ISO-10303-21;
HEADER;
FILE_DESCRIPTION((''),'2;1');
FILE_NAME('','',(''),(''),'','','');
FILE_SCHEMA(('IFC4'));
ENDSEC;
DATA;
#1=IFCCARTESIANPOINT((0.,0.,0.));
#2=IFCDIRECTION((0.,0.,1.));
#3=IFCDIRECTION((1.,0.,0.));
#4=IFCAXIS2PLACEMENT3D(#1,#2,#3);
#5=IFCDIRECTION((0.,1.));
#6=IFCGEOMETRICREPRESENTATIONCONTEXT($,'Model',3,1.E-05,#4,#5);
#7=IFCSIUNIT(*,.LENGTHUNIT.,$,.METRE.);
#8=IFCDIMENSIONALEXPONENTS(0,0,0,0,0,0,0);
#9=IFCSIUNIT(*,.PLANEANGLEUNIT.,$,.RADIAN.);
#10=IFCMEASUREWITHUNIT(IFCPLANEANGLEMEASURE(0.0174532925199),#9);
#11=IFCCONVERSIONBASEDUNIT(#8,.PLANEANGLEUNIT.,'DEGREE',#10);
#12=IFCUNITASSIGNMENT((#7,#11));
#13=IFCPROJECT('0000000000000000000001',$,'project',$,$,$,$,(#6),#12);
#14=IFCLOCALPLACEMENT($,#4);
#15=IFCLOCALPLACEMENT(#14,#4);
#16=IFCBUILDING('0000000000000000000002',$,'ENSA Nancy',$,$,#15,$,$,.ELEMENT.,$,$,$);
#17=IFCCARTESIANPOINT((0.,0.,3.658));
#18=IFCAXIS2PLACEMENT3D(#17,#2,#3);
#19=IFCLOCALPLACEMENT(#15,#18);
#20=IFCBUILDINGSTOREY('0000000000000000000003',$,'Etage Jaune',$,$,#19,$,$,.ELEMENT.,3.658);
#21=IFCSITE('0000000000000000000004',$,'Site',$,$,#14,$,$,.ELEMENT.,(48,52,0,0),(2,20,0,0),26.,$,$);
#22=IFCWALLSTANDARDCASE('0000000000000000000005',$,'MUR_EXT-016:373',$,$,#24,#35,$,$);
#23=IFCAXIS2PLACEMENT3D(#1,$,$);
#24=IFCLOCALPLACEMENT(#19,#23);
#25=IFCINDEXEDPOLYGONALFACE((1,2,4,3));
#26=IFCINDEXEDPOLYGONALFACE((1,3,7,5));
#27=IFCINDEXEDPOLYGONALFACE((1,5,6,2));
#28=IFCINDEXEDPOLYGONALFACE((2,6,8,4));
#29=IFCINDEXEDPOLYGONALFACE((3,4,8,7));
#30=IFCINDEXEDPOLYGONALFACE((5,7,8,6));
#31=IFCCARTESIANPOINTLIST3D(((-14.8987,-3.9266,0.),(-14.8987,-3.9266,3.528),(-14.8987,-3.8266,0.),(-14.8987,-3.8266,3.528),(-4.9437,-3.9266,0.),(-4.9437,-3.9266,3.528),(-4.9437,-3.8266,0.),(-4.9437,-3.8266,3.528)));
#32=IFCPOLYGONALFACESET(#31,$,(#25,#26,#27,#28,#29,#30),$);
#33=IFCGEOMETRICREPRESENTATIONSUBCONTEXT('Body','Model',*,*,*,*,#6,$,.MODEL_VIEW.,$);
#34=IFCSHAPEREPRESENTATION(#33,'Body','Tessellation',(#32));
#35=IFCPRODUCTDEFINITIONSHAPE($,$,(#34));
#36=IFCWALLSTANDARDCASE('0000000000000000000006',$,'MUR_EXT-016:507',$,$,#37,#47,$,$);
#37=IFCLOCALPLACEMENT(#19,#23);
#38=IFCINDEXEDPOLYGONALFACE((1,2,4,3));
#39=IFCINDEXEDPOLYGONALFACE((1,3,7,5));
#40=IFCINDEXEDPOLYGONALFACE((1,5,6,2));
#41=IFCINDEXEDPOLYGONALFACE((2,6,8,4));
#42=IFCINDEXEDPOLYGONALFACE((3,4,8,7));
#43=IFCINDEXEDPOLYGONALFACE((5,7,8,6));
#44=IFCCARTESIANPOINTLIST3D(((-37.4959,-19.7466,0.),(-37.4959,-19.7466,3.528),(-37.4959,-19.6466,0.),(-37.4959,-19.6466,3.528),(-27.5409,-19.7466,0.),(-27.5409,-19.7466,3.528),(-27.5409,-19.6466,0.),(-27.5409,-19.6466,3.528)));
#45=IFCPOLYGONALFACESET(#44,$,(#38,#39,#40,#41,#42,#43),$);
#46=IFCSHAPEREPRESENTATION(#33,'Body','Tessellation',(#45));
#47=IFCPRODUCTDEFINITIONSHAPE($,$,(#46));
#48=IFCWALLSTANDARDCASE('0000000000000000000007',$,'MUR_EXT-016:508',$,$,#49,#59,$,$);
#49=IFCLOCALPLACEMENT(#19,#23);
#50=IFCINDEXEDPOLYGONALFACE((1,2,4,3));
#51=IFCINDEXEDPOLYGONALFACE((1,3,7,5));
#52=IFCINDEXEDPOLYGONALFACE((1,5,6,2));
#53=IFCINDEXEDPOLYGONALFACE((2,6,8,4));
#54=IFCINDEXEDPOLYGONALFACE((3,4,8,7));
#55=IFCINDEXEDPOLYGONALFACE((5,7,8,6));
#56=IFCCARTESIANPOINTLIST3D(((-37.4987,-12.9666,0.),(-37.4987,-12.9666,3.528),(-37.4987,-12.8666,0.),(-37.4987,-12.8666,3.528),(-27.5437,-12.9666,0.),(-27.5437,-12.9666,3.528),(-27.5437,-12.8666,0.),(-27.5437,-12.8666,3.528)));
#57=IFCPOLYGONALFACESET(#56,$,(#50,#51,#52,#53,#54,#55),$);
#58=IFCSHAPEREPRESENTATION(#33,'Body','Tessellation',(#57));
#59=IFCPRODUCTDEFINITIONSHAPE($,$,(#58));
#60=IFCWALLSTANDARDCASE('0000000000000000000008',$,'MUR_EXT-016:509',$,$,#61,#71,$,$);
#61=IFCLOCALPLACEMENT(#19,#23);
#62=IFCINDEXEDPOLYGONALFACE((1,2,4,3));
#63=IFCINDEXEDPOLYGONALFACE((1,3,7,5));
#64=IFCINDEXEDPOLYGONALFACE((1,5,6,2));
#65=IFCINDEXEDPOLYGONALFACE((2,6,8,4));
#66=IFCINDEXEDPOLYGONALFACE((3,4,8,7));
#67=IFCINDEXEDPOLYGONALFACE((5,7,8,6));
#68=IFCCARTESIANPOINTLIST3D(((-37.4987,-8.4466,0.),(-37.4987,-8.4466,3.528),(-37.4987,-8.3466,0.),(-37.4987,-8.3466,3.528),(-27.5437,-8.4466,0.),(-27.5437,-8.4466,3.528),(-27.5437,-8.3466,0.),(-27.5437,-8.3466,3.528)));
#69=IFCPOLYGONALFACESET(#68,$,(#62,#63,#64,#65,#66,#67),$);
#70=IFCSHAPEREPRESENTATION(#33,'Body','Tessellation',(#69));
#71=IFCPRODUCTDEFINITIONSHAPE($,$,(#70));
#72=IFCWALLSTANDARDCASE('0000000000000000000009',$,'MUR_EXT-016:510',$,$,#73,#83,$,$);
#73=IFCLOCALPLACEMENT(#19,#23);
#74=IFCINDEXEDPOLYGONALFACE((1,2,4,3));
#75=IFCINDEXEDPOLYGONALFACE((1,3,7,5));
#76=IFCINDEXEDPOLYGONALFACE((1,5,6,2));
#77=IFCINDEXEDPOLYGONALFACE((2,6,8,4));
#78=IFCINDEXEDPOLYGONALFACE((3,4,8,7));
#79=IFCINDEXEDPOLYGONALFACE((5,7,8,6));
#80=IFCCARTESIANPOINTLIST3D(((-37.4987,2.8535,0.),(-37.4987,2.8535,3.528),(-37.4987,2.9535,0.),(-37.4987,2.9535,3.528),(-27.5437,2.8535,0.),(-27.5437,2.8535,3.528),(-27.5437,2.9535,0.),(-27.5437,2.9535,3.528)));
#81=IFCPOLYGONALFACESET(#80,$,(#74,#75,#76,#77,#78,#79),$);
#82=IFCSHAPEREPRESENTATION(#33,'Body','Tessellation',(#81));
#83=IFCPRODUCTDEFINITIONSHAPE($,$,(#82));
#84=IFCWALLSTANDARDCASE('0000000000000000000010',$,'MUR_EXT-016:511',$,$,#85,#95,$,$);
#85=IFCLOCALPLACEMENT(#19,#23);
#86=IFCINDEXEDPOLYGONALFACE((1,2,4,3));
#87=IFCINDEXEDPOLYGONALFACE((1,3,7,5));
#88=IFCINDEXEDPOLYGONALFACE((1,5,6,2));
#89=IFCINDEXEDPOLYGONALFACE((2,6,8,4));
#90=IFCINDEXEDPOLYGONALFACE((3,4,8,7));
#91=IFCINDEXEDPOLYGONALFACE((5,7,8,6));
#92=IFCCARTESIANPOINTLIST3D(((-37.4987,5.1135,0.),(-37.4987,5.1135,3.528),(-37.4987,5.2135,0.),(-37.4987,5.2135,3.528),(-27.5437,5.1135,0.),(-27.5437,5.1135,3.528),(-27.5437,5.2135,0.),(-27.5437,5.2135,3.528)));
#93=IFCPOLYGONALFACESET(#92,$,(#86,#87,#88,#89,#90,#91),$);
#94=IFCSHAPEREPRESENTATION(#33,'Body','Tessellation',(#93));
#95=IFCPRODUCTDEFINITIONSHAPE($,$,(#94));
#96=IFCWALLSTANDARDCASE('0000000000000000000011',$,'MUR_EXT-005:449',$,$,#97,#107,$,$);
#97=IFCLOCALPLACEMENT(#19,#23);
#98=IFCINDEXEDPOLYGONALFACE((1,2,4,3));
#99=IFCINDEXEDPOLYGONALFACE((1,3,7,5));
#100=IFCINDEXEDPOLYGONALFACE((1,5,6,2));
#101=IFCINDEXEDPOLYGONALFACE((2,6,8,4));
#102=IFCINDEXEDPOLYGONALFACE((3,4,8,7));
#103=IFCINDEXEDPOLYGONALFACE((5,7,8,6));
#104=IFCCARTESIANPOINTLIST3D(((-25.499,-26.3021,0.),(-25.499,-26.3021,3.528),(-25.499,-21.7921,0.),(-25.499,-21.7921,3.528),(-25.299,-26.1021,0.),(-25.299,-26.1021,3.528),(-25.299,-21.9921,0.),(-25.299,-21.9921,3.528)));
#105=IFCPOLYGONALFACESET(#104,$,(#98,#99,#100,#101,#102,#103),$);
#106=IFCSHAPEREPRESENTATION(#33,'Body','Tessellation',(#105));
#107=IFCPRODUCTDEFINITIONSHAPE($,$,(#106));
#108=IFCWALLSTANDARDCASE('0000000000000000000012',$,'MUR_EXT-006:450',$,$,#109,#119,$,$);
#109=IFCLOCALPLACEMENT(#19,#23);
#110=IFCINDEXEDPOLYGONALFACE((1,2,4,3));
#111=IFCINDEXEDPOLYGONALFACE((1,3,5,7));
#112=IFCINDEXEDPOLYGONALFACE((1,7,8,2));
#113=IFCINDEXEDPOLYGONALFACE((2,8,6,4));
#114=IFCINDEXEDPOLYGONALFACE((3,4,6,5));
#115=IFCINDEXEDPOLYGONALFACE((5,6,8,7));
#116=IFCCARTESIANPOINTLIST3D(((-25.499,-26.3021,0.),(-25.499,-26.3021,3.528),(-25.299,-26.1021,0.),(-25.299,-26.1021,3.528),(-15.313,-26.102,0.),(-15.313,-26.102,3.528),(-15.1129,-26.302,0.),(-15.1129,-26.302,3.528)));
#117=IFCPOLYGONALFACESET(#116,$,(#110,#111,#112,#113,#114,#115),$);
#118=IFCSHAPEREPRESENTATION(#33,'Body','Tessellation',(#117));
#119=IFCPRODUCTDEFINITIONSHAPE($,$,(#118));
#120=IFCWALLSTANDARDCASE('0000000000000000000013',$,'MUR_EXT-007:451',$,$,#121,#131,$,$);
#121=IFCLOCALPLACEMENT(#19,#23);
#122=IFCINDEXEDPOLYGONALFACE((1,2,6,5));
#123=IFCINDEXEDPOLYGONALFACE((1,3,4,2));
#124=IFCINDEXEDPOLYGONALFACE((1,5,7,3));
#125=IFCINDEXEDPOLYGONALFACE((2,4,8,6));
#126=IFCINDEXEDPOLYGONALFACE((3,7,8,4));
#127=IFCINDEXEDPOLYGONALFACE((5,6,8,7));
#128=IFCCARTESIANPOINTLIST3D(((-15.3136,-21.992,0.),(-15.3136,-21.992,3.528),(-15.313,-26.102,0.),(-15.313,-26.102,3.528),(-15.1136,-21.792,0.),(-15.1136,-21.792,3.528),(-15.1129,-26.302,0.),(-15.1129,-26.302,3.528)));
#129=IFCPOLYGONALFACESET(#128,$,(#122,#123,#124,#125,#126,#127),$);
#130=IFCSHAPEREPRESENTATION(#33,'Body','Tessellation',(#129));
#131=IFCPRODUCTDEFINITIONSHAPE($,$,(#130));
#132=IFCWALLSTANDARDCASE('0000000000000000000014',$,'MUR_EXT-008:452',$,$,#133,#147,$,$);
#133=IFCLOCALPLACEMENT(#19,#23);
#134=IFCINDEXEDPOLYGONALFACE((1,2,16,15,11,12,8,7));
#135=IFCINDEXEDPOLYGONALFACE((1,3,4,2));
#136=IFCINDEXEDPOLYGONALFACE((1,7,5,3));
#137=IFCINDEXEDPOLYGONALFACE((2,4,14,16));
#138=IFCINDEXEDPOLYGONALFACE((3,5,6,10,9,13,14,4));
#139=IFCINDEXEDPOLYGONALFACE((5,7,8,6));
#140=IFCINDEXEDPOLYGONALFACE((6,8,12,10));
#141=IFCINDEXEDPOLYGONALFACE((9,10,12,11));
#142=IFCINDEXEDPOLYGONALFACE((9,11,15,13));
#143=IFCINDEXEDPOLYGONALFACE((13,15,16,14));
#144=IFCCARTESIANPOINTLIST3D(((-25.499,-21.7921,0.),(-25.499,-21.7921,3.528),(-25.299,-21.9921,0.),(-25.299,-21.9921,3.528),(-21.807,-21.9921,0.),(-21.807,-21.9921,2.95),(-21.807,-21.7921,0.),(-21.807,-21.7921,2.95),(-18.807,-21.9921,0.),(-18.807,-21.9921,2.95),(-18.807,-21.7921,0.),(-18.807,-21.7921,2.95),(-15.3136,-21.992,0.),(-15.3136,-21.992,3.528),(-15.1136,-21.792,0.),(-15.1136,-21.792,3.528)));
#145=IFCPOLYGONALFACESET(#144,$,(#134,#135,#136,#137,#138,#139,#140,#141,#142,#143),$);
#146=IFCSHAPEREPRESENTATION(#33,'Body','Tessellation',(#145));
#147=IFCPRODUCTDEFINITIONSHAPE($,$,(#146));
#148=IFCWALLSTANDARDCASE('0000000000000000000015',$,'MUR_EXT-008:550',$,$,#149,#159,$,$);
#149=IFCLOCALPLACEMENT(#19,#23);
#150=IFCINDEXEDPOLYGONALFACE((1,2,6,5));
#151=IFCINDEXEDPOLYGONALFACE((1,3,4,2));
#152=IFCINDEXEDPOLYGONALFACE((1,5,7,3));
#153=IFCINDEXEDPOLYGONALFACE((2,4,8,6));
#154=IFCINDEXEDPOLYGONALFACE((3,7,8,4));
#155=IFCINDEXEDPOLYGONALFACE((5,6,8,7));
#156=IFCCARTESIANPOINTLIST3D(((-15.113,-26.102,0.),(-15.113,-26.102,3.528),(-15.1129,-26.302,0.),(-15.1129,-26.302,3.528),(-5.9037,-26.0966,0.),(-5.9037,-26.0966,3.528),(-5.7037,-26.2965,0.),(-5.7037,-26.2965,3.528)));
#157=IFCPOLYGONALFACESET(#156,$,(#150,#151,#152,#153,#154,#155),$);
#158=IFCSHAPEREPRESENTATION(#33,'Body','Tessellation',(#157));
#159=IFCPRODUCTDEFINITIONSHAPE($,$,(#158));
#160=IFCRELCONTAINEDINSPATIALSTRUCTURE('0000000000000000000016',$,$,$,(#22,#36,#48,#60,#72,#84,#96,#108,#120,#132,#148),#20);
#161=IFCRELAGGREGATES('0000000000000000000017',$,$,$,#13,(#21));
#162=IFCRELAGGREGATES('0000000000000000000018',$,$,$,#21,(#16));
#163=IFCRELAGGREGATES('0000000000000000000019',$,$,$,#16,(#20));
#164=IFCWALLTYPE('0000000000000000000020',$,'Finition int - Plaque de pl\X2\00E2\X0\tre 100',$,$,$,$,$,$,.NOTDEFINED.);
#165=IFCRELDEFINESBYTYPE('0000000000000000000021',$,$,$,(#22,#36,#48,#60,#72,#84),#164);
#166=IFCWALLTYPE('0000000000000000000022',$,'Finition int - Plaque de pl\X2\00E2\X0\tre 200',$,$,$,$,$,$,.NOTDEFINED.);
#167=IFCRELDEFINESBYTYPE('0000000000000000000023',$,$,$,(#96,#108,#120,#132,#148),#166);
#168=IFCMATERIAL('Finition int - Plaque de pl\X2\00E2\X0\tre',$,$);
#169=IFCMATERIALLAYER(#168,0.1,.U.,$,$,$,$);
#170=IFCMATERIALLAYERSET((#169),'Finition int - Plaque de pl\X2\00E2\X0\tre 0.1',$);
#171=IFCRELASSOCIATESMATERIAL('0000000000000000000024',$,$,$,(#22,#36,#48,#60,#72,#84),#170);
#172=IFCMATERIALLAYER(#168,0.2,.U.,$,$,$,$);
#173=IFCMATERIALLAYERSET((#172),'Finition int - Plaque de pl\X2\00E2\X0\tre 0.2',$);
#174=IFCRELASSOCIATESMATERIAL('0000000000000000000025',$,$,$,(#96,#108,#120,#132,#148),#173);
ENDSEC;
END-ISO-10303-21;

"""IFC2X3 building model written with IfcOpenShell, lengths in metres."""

from ifc_helpers import new_model, entity, si_unit, converted_unit, direction, frame, origin_with_axes, origin_2d_with_axis, place, context, subcontext, project, spatial, polyline, rectangle, outline, extrude, material, layer, layer_set, layer_usage, type_object, element, save


model = new_model("IFC2X3")

# Units and contexts
model_context = context("Model", 3, precision=1e-05, world=origin_with_axes(), true_north=direction((0.0, 1.0)))
body_context = subcontext(model_context, "Body", "Model", "MODEL_VIEW")
ifc_project = project(units=[si_unit("LENGTHUNIT", "METRE"), converted_unit("PLANEANGLEUNIT", "DEGREE", entity("IfcPlaneAngleMeasure", 0.0174532925199), si_unit("PLANEANGLEUNIT", "RADIAN"), dimensions=[0, 0, 0, 0, 0, 0, 0])], contexts=[model_context])

# Site, building, storey
site_placement = place(None, origin_with_axes())
site = spatial("IfcSite", under=ifc_project, at=site_placement, Name="Site", CompositionType="ELEMENT", RefLatitude=(48, 52, 0, 0), RefLongitude=(2, 20, 0, 0), RefElevation=26.0)
building_placement = place(site_placement, origin_with_axes())
building = spatial("IfcBuilding", under=site, at=building_placement, Name="ENSA Nancy", CompositionType="ELEMENT")
storey_placement = place(building_placement, frame((0.0, 0.0, 3.658), z_axis=(0.0, 0.0, 1.0), x_axis=(1.0, 0.0, 0.0)))
storey = spatial("IfcBuildingStorey", under=building, at=storey_placement, Name="Etage Jaune", CompositionType="ELEMENT", Elevation=3.658)

# Walls
ifc_material_1 = material(Name="Finition int - Plaque de plâtre")
ifc_layer_1 = layer(ifc_material_1, 0.1, ventilated="UNKNOWN")
ifc_layer_set_1 = layer_set([ifc_layer_1], Name="Finition int - Plaque de plâtre 0.1")
ifc_layer_usage_1 = layer_usage(ifc_layer_set_1, "AXIS2", "NEGATIVE", 0.1)
wall_type_1 = type_object("IfcWallType", Name="Finition int - Plaque de plâtre 100", PredefinedType="NOTDEFINED")
wall_1_placement = place(storey_placement, frame((-14.8987, -3.9266, 0.0), z_axis=(0.0, 0.0, 1.0), x_axis=(1.0, 0.0, 0.0)))
element("IfcWallStandardCase", 1, at=wall_1_placement, inside=storey, type_object=wall_type_1, material=ifc_layer_usage_1, Name="MUR_EXT-016:373", context=body_context, shape_type="SweptSolid", body=[
    extrude(outline(polyline([(0.0, 0.0), (9.955, 0.0), (9.955, 0.1), (0.0, 0.1), (0.0, 0.0)])), origin_with_axes(), (0.0, 0.0, 1.0), 3.528),
])
ifc_layer_usage_2 = layer_usage(ifc_layer_set_1, "AXIS2", "NEGATIVE", 0.1)
wall_2_placement = place(storey_placement, frame((-37.4959, -19.7466, 0.0), z_axis=(0.0, 0.0, 1.0), x_axis=(1.0, 0.0, 0.0)))
element("IfcWallStandardCase", 2, at=wall_2_placement, inside=storey, type_object=wall_type_1, material=ifc_layer_usage_2, Name="MUR_EXT-016:507", context=body_context, shape_type="SweptSolid", body=[
    extrude(outline(polyline([(0.0, 0.0), (9.955, 0.0), (9.955, 0.1), (0.0, 0.1), (0.0, 0.0)])), origin_with_axes(), (0.0, 0.0, 1.0), 3.528),
])
ifc_layer_usage_3 = layer_usage(ifc_layer_set_1, "AXIS2", "NEGATIVE", 0.1)
wall_3_placement = place(storey_placement, frame((-37.4987, -12.9666, 0.0), z_axis=(0.0, 0.0, 1.0), x_axis=(1.0, 0.0, 0.0)))
element("IfcWallStandardCase", 3, at=wall_3_placement, inside=storey, type_object=wall_type_1, material=ifc_layer_usage_3, Name="MUR_EXT-016:508", context=body_context, shape_type="SweptSolid", body=[
    extrude(outline(polyline([(0.0, 0.0), (9.955, 0.0), (9.955, 0.1), (0.0, 0.1), (0.0, 0.0)])), origin_with_axes(), (0.0, 0.0, 1.0), 3.528),
])
ifc_layer_usage_4 = layer_usage(ifc_layer_set_1, "AXIS2", "NEGATIVE", 0.1)
wall_4_placement = place(storey_placement, frame((-37.4987, -8.4466, 0.0), z_axis=(0.0, 0.0, 1.0), x_axis=(1.0, 0.0, 0.0)))
element("IfcWallStandardCase", 4, at=wall_4_placement, inside=storey, type_object=wall_type_1, material=ifc_layer_usage_4, Name="MUR_EXT-016:509", context=body_context, shape_type="SweptSolid", body=[
    extrude(outline(polyline([(0.0, 0.0), (9.955, 0.0), (9.955, 0.1), (0.0, 0.1), (0.0, 0.0)])), origin_with_axes(), (0.0, 0.0, 1.0), 3.528),
])
ifc_layer_usage_5 = layer_usage(ifc_layer_set_1, "AXIS2", "NEGATIVE", 0.1)
wall_5_placement = place(storey_placement, frame((-37.4987, 2.8535, 0.0), z_axis=(0.0, 0.0, 1.0), x_axis=(1.0, 0.0, 0.0)))
element("IfcWallStandardCase", 5, at=wall_5_placement, inside=storey, type_object=wall_type_1, material=ifc_layer_usage_5, Name="MUR_EXT-016:510", context=body_context, shape_type="SweptSolid", body=[
    extrude(outline(polyline([(0.0, 0.0), (9.955, 0.0), (9.955, 0.1), (0.0, 0.1), (0.0, 0.0)])), origin_with_axes(), (0.0, 0.0, 1.0), 3.528),
])
ifc_layer_usage_6 = layer_usage(ifc_layer_set_1, "AXIS2", "NEGATIVE", 0.1)
wall_6_placement = place(storey_placement, frame((-37.4987, 5.1135, 0.0), z_axis=(0.0, 0.0, 1.0), x_axis=(1.0, 0.0, 0.0)))
element("IfcWallStandardCase", 6, at=wall_6_placement, inside=storey, type_object=wall_type_1, material=ifc_layer_usage_6, Name="MUR_EXT-016:511", context=body_context, shape_type="SweptSolid", body=[
    extrude(outline(polyline([(0.0, 0.0), (9.955, 0.0), (9.955, 0.1), (0.0, 0.1), (0.0, 0.0)])), origin_with_axes(), (0.0, 0.0, 1.0), 3.528),
])
ifc_layer_2 = layer(ifc_material_1, 0.2, ventilated="UNKNOWN")
ifc_layer_set_2 = layer_set([ifc_layer_2], Name="Finition int - Plaque de plâtre 0.2")
ifc_layer_usage_7 = layer_usage(ifc_layer_set_2, "AXIS2", "POSITIVE", 0.0)
wall_type_2 = type_object("IfcWallType", Name="Finition int - Plaque de plâtre 200", PredefinedType="NOTDEFINED")
wall_7_placement = place(storey_placement, frame((-25.499, -21.7921, 0.0), z_axis=(0.0, 0.0, 1.0), x_axis=(0.0, -1.0, 0.0)))
element("IfcWallStandardCase", 7, at=wall_7_placement, inside=storey, type_object=wall_type_2, material=ifc_layer_usage_7, Name="MUR_EXT-005:449", context=body_context, shape_type="SweptSolid", body=[
    extrude(outline(polyline([(0.0, 0.0), (4.51, 0.0), (4.31, 0.2), (0.2, 0.2), (0.0, 0.0)])), origin_with_axes(), (0.0, 0.0, 1.0), 3.528),
])
ifc_layer_usage_8 = layer_usage(ifc_layer_set_2, "AXIS2", "POSITIVE", 0.0)
wall_8_placement = place(storey_placement, frame((-25.499, -26.3021, 0.0), z_axis=(0.0, 0.0, 1.0), x_axis=(1.0, 0.000003, 0.0)))
element("IfcWallStandardCase", 8, at=wall_8_placement, inside=storey, type_object=wall_type_2, material=ifc_layer_usage_8, Name="MUR_EXT-006:450", context=body_context, shape_type="SweptSolid", body=[
    extrude(outline(polyline([(0.0, 0.0), (10.386, 0.0), (10.186, 0.2), (0.2, 0.2), (0.0, 0.0)])), origin_with_axes(), (0.0, 0.0, 1.0), 3.528),
])
ifc_layer_usage_9 = layer_usage(ifc_layer_set_2, "AXIS2", "POSITIVE", 0.0)
wall_9_placement = place(storey_placement, frame((-15.1129, -26.302, 0.0), z_axis=(0.0, 0.0, 1.0), x_axis=(-0.00015, 1.0, 0.0)))
element("IfcWallStandardCase", 9, at=wall_9_placement, inside=storey, type_object=wall_type_2, material=ifc_layer_usage_9, Name="MUR_EXT-007:451", context=body_context, shape_type="SweptSolid", body=[
    extrude(outline(polyline([(0.0, 0.0), (4.51, 0.0), (4.31, 0.2), (0.2, 0.2), (0.0, 0.0)])), origin_with_axes(), (0.0, 0.0, 1.0), 3.528),
])

# Wall, opening
ifc_layer_usage_10 = layer_usage(ifc_layer_set_2, "AXIS2", "POSITIVE", 0.0)
wall_10_placement = place(storey_placement, frame((-15.1136, -21.792, 0.0), z_axis=(0.0, 0.0, 1.0), x_axis=(-1.0, -0.000003, 0.0)))
wall_10 = element("IfcWallStandardCase", 10, at=wall_10_placement, inside=storey, type_object=wall_type_2, material=ifc_layer_usage_10, Name="MUR_EXT-008:452", context=body_context, shape_type="SweptSolid", body=[
    extrude(outline(polyline([(0.0, 0.0), (10.3854, 0.0), (10.1854, 0.2), (0.2, 0.2), (0.0, 0.0)])), origin_with_axes(), (0.0, 0.0, 1.0), 3.528),
])
opening_1_placement = place(wall_10_placement, frame((5.1934, 0.0, 0.0), z_axis=(0.0, 0.0, 1.0), x_axis=(1.0, 0.0, 0.0)))
element("IfcOpeningElement", 11, at=opening_1_placement, cuts=wall_10, context=body_context, shape_type="SweptSolid", body=[
    extrude(rectangle(XDim=3.0, YDim=2.95, at=origin_2d_with_axis()), frame((0.0, 0.2, 1.475), z_axis=(0.0, 1.0, 0.0), x_axis=(-1.0, 0.0, 0.0)), (0.0, 0.0, -1.0), 0.6),
])

# Wall
ifc_layer_usage_11 = layer_usage(ifc_layer_set_2, "AXIS2", "NEGATIVE", 0.0)
wall_11_placement = place(storey_placement, frame((-5.7037, -26.2965, 0.0), z_axis=(0.0, 0.0, 1.0), x_axis=(-1.0, -0.000589, 0.0)))
element("IfcWallStandardCase", 12, at=wall_11_placement, inside=storey, type_object=wall_type_2, material=ifc_layer_usage_11, Name="MUR_EXT-008:550", context=body_context, shape_type="SweptSolid", body=[
    extrude(outline(polyline([(0.1999, -0.2), (9.4092, -0.2), (9.4092, 0.0), (0.0, 0.0), (0.1999, -0.2)])), origin_with_axes(), (0.0, 0.0, 1.0), 3.528),
])

save(model, "model.ifc")
